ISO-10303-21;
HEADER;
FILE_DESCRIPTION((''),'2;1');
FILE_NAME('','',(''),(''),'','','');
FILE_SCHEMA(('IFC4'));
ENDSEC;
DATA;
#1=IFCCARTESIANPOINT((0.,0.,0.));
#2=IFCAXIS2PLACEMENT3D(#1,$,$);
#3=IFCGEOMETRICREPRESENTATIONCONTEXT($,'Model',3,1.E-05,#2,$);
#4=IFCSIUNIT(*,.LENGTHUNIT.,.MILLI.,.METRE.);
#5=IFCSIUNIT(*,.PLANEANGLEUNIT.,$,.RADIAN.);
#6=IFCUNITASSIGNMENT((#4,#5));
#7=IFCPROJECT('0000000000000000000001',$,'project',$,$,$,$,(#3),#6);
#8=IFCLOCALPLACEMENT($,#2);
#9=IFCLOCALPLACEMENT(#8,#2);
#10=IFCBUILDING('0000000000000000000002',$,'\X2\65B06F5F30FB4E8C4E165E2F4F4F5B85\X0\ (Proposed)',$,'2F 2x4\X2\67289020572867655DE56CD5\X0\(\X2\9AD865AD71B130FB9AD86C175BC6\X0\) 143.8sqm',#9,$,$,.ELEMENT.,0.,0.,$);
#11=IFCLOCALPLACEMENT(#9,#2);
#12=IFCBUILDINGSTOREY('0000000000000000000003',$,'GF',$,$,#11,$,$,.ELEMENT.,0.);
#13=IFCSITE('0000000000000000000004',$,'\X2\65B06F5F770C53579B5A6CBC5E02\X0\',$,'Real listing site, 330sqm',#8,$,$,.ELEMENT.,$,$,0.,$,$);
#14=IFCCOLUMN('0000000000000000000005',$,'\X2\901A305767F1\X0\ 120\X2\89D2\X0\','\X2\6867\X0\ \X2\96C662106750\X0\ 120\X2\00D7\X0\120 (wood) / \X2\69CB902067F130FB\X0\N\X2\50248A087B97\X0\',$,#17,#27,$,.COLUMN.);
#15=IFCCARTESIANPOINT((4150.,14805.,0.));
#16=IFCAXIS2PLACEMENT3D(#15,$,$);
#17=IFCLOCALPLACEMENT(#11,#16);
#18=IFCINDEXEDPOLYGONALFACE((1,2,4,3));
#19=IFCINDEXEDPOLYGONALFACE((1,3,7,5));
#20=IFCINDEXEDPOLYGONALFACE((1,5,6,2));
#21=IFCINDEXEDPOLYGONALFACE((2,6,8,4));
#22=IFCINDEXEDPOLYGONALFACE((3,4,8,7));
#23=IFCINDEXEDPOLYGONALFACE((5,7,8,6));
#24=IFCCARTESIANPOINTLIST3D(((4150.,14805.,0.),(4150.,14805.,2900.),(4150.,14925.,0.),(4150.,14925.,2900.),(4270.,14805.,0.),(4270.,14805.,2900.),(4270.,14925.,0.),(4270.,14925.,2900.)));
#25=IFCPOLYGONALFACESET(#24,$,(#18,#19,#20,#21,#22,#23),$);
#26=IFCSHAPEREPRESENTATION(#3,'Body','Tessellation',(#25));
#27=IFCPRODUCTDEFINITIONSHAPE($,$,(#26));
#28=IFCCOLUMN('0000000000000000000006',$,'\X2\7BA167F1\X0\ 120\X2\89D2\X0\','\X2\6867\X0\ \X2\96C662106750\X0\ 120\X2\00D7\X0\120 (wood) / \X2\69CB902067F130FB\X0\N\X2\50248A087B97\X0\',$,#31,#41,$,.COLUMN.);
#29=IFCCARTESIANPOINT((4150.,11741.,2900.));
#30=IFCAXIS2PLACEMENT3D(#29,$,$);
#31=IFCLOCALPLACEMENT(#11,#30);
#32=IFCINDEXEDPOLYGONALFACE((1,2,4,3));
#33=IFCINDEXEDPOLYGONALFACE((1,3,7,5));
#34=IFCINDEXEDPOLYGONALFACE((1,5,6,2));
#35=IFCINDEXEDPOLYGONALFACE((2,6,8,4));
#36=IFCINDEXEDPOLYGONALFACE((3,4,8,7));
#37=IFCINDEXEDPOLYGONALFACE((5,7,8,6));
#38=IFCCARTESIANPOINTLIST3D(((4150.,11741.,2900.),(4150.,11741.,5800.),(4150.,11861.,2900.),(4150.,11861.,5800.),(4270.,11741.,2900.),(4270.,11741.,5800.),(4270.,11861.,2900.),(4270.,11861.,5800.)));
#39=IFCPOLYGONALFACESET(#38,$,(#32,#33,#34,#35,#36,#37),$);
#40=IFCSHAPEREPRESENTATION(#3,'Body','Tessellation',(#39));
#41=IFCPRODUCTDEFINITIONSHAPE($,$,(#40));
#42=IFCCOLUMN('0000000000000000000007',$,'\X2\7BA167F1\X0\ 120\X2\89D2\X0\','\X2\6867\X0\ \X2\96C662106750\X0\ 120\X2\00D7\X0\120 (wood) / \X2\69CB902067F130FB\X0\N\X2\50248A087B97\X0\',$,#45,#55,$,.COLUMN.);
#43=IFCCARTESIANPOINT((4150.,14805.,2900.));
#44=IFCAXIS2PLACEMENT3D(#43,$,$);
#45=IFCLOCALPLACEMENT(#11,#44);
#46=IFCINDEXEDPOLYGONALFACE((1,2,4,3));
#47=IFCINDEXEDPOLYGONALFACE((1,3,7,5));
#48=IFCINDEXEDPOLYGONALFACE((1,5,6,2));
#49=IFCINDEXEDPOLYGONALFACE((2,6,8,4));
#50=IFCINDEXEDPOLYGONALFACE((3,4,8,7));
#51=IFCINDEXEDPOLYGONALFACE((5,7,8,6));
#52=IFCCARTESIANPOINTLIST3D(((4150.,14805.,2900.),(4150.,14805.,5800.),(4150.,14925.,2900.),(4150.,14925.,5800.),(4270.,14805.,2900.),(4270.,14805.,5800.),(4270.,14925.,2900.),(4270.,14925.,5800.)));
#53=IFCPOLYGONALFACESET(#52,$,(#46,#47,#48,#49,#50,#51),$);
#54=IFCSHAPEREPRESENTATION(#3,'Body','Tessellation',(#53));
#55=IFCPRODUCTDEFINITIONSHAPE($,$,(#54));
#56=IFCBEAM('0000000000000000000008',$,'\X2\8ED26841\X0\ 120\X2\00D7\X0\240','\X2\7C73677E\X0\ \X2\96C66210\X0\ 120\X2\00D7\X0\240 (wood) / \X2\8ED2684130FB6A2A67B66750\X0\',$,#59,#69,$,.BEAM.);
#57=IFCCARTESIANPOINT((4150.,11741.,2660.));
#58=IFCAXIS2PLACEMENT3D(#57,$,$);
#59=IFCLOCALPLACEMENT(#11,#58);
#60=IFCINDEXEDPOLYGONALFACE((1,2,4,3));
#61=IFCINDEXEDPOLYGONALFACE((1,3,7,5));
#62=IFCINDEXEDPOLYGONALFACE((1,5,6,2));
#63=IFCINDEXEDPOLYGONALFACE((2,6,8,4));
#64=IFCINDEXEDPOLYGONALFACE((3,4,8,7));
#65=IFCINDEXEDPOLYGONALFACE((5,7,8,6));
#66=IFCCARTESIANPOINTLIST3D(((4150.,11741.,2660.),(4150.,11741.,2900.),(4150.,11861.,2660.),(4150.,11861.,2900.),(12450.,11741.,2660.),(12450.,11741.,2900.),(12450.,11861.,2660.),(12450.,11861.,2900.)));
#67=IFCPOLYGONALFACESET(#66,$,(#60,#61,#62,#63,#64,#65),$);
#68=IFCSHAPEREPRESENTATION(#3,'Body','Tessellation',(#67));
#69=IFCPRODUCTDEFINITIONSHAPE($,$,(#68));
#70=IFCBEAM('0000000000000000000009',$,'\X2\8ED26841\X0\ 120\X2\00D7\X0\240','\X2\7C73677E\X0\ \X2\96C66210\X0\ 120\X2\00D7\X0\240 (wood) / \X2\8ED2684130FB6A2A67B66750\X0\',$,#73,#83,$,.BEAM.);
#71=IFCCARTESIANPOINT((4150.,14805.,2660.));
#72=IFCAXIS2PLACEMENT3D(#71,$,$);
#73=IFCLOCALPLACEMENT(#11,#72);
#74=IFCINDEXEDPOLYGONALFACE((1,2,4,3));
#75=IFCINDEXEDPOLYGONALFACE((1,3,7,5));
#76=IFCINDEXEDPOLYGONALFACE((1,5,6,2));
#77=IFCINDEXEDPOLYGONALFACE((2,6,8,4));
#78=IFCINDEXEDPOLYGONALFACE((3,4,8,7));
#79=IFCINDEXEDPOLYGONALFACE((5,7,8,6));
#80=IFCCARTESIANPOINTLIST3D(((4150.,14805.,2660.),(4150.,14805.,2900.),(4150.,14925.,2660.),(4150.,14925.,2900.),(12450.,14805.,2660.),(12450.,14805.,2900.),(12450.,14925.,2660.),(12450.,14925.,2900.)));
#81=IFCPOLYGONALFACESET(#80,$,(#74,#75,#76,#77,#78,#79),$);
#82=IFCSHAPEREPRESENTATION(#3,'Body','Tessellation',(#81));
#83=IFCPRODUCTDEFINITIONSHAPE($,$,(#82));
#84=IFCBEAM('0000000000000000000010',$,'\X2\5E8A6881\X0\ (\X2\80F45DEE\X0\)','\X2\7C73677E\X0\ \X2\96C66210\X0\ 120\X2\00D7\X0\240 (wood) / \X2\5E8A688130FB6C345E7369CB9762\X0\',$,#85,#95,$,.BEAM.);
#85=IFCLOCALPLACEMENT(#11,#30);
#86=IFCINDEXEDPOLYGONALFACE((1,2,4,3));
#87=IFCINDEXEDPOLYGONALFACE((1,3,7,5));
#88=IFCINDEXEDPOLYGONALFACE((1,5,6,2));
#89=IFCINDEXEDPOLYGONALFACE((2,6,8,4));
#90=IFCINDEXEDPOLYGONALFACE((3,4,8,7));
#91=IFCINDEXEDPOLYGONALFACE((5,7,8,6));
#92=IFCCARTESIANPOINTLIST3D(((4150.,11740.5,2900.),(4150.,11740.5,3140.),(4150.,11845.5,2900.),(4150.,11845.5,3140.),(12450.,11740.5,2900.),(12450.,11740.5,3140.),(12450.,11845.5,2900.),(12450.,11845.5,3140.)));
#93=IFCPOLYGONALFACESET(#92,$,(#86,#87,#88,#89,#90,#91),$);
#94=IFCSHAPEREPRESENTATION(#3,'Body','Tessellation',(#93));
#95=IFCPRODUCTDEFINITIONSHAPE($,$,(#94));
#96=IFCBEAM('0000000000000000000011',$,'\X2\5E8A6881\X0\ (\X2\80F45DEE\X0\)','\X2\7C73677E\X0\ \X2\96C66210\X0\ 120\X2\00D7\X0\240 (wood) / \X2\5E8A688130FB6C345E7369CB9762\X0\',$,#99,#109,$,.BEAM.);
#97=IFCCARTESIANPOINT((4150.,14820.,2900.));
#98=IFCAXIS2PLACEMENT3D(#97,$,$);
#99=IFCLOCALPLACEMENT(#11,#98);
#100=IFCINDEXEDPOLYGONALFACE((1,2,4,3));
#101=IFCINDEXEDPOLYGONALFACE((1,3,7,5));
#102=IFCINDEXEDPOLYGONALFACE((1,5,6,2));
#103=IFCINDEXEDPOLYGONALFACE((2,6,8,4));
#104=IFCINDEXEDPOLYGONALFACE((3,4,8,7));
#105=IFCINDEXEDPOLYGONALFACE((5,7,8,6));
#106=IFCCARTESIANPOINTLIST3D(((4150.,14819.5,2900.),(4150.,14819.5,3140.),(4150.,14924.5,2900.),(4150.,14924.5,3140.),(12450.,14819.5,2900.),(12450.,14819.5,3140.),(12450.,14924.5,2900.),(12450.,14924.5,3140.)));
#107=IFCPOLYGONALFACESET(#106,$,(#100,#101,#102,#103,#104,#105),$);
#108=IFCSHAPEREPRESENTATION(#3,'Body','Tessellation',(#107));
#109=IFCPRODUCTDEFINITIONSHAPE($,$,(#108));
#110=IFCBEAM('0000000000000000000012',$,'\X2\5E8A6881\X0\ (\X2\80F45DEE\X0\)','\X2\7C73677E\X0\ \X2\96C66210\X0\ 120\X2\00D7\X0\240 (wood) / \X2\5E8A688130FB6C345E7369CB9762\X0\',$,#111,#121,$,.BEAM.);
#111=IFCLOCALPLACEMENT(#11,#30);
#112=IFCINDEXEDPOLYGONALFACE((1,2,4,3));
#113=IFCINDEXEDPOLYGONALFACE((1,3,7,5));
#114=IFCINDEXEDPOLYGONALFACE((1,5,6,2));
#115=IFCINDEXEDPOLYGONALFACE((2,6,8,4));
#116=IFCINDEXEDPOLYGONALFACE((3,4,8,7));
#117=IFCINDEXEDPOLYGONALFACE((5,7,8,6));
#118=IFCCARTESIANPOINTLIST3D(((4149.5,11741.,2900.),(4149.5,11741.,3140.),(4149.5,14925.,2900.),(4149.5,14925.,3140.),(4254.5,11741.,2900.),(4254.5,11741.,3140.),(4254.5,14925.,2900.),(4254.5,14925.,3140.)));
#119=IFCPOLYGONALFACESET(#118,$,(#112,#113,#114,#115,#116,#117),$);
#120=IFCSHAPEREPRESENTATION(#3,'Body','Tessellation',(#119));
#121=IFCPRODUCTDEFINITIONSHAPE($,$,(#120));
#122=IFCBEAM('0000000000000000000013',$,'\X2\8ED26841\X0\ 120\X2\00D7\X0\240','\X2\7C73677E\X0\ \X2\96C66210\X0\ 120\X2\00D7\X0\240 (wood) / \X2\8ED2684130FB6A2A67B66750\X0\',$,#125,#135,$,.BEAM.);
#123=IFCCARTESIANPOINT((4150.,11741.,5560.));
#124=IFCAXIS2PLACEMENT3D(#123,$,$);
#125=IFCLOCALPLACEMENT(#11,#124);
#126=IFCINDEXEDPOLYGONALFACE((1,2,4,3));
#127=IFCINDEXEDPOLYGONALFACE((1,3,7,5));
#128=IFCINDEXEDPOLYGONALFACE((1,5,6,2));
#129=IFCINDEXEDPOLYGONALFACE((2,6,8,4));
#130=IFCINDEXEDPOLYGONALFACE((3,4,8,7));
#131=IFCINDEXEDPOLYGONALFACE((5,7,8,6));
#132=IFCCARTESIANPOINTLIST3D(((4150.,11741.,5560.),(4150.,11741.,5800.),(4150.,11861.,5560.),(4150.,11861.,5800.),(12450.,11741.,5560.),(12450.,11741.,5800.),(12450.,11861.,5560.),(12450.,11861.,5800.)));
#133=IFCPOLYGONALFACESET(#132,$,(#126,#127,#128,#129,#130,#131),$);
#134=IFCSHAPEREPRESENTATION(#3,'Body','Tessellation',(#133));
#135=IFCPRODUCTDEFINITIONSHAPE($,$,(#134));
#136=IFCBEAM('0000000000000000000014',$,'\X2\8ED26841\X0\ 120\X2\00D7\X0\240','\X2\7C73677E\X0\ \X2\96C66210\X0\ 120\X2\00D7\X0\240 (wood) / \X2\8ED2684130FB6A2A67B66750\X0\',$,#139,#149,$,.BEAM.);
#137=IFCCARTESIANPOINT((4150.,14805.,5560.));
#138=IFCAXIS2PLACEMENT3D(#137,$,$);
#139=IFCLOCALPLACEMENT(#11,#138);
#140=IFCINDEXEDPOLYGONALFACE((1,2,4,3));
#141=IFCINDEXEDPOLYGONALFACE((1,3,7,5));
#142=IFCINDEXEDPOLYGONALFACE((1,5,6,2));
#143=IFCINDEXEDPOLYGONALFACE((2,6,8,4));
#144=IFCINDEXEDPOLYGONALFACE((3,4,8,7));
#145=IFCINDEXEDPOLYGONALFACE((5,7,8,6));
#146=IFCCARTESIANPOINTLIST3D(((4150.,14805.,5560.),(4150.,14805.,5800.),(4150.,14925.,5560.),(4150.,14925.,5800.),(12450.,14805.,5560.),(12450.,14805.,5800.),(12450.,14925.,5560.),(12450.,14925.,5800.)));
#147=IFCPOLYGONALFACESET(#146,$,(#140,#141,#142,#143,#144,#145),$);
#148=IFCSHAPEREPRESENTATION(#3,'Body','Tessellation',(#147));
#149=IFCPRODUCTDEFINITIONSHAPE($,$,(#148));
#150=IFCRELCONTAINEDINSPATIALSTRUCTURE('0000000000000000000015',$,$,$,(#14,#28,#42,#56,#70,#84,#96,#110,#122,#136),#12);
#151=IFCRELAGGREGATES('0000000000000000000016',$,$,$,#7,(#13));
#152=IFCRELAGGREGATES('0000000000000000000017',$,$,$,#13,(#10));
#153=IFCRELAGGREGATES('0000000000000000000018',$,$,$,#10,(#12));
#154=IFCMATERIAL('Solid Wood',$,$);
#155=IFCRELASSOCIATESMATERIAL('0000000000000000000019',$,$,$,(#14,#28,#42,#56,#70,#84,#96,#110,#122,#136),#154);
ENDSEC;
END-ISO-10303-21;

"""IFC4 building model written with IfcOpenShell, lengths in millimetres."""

from ifc_helpers import new_model, si_unit, frame, frame_2d, origin, place, context, project, spatial, rectangle, extrude, material, element, save


model = new_model("IFC4")

# Units and contexts
model_context = context("Model", 3, precision=1e-05, world=origin())
ifc_project = project(units=[si_unit("LENGTHUNIT", "METRE", prefix="MILLI"), si_unit("PLANEANGLEUNIT", "RADIAN")], contexts=[model_context])

# Site, building, storey
site_placement = place(None, origin())
site = spatial("IfcSite", under=ifc_project, at=site_placement, Name="新潟県南魚沼市", ObjectType="Real listing site, 330sqm", CompositionType="ELEMENT", RefElevation=0.0)
building_placement = place(site_placement, origin())
building = spatial("IfcBuilding", under=site, at=building_placement, Name="新潟・二世帯住宅 (Proposed)", ObjectType="2F 2x4木造在来工法(高断熱・高気密) 143.8sqm", CompositionType="ELEMENT", ElevationOfRefHeight=0.0, ElevationOfTerrain=0.0)
storey_placement = place(building_placement, origin())
storey = spatial("IfcBuildingStorey", under=building, at=storey_placement, Name="GF", CompositionType="ELEMENT", Elevation=0.0)

# Columns
ifc_material_1 = material(Name="Solid Wood")
column_1_placement = place(storey_placement, frame((4150.0, 14805.0, 0.0)))
element("IfcColumn", 1, at=column_1_placement, inside=storey, material=ifc_material_1, Name="通し柱 120角", Description="桧 集成材 120×120 (wood) / 構造柱・N値計算", PredefinedType="COLUMN", context=model_context, shape_type="SweptSolid", body=[
    extrude(rectangle(XDim=120.0, YDim=120.0, at=frame_2d((60.0, 60.0))), frame((4150.0, 14805.0, 0.0)), (0.0, 0.0, 1.0), 2900.0),
])
column_2_placement = place(storey_placement, frame((4150.0, 11741.0, 2900.0)))
element("IfcColumn", 2, at=column_2_placement, inside=storey, material=ifc_material_1, Name="管柱 120角", Description="桧 集成材 120×120 (wood) / 構造柱・N値計算", PredefinedType="COLUMN", context=model_context, shape_type="SweptSolid", body=[
    extrude(rectangle(XDim=120.0, YDim=120.0, at=frame_2d((60.0, 60.0))), frame((4150.0, 11741.0, 2900.0)), (0.0, 0.0, 1.0), 2900.0),
])
column_3_placement = place(storey_placement, frame((4150.0, 14805.0, 2900.0)))
element("IfcColumn", 3, at=column_3_placement, inside=storey, material=ifc_material_1, Name="管柱 120角", Description="桧 集成材 120×120 (wood) / 構造柱・N値計算", PredefinedType="COLUMN", context=model_context, shape_type="SweptSolid", body=[
    extrude(rectangle(XDim=120.0, YDim=120.0, at=frame_2d((60.0, 60.0))), frame((4150.0, 14805.0, 2900.0)), (0.0, 0.0, 1.0), 2900.0),
])

# Beams
beam_1_placement = place(storey_placement, frame((4150.0, 11741.0, 2660.0)))
element("IfcBeam", 4, at=beam_1_placement, inside=storey, material=ifc_material_1, Name="軒桁 120×240", Description="米松 集成 120×240 (wood) / 軒桁・横架材", PredefinedType="BEAM", context=model_context, shape_type="SweptSolid", body=[
    extrude(rectangle(XDim=8300.0, YDim=120.0, at=frame_2d((4150.0, 60.0))), frame((4150.0, 11741.0, 2660.0)), (0.0, 0.0, 1.0), 240.0),
])
beam_2_placement = place(storey_placement, frame((4150.0, 14805.0, 2660.0)))
element("IfcBeam", 5, at=beam_2_placement, inside=storey, material=ifc_material_1, Name="軒桁 120×240", Description="米松 集成 120×240 (wood) / 軒桁・横架材", PredefinedType="BEAM", context=model_context, shape_type="SweptSolid", body=[
    extrude(rectangle(XDim=8300.0, YDim=120.0, at=frame_2d((4150.0, 60.0))), frame((4150.0, 14805.0, 2660.0)), (0.0, 0.0, 1.0), 240.0),
])
beam_3_placement = place(storey_placement, frame((4150.0, 11741.0, 2900.0)))
element("IfcBeam", 6, at=beam_3_placement, inside=storey, material=ifc_material_1, Name="床梁 (胴差)", Description="米松 集成 120×240 (wood) / 床梁・水平構面", PredefinedType="BEAM", context=model_context, shape_type="SweptSolid", body=[
    extrude(rectangle(XDim=8300.0, YDim=105.0, at=frame_2d((4150.0, 52.0))), frame((4150.0, 11741.0, 2900.0)), (0.0, 0.0, 1.0), 240.0),
])
beam_4_placement = place(storey_placement, frame((4150.0, 14820.0, 2900.0)))
element("IfcBeam", 7, at=beam_4_placement, inside=storey, material=ifc_material_1, Name="床梁 (胴差)", Description="米松 集成 120×240 (wood) / 床梁・水平構面", PredefinedType="BEAM", context=model_context, shape_type="SweptSolid", body=[
    extrude(rectangle(XDim=8300.0, YDim=105.0, at=frame_2d((4150.0, 52.0))), frame((4150.0, 14820.0, 2900.0)), (0.0, 0.0, 1.0), 240.0),
])
beam_5_placement = place(storey_placement, frame((4150.0, 11741.0, 2900.0)))
element("IfcBeam", 8, at=beam_5_placement, inside=storey, material=ifc_material_1, Name="床梁 (胴差)", Description="米松 集成 120×240 (wood) / 床梁・水平構面", PredefinedType="BEAM", context=model_context, shape_type="SweptSolid", body=[
    extrude(rectangle(XDim=105.0, YDim=3184.0, at=frame_2d((52.0, 1592.0))), frame((4150.0, 11741.0, 2900.0)), (0.0, 0.0, 1.0), 240.0),
])
beam_6_placement = place(storey_placement, frame((4150.0, 11741.0, 5560.0)))
element("IfcBeam", 9, at=beam_6_placement, inside=storey, material=ifc_material_1, Name="軒桁 120×240", Description="米松 集成 120×240 (wood) / 軒桁・横架材", PredefinedType="BEAM", context=model_context, shape_type="SweptSolid", body=[
    extrude(rectangle(XDim=8300.0, YDim=120.0, at=frame_2d((4150.0, 60.0))), frame((4150.0, 11741.0, 5560.0)), (0.0, 0.0, 1.0), 240.0),
])
beam_7_placement = place(storey_placement, frame((4150.0, 14805.0, 5560.0)))
element("IfcBeam", 10, at=beam_7_placement, inside=storey, material=ifc_material_1, Name="軒桁 120×240", Description="米松 集成 120×240 (wood) / 軒桁・横架材", PredefinedType="BEAM", context=model_context, shape_type="SweptSolid", body=[
    extrude(rectangle(XDim=8300.0, YDim=120.0, at=frame_2d((4150.0, 60.0))), frame((4150.0, 14805.0, 5560.0)), (0.0, 0.0, 1.0), 240.0),
])

save(model, "model.ifc")
